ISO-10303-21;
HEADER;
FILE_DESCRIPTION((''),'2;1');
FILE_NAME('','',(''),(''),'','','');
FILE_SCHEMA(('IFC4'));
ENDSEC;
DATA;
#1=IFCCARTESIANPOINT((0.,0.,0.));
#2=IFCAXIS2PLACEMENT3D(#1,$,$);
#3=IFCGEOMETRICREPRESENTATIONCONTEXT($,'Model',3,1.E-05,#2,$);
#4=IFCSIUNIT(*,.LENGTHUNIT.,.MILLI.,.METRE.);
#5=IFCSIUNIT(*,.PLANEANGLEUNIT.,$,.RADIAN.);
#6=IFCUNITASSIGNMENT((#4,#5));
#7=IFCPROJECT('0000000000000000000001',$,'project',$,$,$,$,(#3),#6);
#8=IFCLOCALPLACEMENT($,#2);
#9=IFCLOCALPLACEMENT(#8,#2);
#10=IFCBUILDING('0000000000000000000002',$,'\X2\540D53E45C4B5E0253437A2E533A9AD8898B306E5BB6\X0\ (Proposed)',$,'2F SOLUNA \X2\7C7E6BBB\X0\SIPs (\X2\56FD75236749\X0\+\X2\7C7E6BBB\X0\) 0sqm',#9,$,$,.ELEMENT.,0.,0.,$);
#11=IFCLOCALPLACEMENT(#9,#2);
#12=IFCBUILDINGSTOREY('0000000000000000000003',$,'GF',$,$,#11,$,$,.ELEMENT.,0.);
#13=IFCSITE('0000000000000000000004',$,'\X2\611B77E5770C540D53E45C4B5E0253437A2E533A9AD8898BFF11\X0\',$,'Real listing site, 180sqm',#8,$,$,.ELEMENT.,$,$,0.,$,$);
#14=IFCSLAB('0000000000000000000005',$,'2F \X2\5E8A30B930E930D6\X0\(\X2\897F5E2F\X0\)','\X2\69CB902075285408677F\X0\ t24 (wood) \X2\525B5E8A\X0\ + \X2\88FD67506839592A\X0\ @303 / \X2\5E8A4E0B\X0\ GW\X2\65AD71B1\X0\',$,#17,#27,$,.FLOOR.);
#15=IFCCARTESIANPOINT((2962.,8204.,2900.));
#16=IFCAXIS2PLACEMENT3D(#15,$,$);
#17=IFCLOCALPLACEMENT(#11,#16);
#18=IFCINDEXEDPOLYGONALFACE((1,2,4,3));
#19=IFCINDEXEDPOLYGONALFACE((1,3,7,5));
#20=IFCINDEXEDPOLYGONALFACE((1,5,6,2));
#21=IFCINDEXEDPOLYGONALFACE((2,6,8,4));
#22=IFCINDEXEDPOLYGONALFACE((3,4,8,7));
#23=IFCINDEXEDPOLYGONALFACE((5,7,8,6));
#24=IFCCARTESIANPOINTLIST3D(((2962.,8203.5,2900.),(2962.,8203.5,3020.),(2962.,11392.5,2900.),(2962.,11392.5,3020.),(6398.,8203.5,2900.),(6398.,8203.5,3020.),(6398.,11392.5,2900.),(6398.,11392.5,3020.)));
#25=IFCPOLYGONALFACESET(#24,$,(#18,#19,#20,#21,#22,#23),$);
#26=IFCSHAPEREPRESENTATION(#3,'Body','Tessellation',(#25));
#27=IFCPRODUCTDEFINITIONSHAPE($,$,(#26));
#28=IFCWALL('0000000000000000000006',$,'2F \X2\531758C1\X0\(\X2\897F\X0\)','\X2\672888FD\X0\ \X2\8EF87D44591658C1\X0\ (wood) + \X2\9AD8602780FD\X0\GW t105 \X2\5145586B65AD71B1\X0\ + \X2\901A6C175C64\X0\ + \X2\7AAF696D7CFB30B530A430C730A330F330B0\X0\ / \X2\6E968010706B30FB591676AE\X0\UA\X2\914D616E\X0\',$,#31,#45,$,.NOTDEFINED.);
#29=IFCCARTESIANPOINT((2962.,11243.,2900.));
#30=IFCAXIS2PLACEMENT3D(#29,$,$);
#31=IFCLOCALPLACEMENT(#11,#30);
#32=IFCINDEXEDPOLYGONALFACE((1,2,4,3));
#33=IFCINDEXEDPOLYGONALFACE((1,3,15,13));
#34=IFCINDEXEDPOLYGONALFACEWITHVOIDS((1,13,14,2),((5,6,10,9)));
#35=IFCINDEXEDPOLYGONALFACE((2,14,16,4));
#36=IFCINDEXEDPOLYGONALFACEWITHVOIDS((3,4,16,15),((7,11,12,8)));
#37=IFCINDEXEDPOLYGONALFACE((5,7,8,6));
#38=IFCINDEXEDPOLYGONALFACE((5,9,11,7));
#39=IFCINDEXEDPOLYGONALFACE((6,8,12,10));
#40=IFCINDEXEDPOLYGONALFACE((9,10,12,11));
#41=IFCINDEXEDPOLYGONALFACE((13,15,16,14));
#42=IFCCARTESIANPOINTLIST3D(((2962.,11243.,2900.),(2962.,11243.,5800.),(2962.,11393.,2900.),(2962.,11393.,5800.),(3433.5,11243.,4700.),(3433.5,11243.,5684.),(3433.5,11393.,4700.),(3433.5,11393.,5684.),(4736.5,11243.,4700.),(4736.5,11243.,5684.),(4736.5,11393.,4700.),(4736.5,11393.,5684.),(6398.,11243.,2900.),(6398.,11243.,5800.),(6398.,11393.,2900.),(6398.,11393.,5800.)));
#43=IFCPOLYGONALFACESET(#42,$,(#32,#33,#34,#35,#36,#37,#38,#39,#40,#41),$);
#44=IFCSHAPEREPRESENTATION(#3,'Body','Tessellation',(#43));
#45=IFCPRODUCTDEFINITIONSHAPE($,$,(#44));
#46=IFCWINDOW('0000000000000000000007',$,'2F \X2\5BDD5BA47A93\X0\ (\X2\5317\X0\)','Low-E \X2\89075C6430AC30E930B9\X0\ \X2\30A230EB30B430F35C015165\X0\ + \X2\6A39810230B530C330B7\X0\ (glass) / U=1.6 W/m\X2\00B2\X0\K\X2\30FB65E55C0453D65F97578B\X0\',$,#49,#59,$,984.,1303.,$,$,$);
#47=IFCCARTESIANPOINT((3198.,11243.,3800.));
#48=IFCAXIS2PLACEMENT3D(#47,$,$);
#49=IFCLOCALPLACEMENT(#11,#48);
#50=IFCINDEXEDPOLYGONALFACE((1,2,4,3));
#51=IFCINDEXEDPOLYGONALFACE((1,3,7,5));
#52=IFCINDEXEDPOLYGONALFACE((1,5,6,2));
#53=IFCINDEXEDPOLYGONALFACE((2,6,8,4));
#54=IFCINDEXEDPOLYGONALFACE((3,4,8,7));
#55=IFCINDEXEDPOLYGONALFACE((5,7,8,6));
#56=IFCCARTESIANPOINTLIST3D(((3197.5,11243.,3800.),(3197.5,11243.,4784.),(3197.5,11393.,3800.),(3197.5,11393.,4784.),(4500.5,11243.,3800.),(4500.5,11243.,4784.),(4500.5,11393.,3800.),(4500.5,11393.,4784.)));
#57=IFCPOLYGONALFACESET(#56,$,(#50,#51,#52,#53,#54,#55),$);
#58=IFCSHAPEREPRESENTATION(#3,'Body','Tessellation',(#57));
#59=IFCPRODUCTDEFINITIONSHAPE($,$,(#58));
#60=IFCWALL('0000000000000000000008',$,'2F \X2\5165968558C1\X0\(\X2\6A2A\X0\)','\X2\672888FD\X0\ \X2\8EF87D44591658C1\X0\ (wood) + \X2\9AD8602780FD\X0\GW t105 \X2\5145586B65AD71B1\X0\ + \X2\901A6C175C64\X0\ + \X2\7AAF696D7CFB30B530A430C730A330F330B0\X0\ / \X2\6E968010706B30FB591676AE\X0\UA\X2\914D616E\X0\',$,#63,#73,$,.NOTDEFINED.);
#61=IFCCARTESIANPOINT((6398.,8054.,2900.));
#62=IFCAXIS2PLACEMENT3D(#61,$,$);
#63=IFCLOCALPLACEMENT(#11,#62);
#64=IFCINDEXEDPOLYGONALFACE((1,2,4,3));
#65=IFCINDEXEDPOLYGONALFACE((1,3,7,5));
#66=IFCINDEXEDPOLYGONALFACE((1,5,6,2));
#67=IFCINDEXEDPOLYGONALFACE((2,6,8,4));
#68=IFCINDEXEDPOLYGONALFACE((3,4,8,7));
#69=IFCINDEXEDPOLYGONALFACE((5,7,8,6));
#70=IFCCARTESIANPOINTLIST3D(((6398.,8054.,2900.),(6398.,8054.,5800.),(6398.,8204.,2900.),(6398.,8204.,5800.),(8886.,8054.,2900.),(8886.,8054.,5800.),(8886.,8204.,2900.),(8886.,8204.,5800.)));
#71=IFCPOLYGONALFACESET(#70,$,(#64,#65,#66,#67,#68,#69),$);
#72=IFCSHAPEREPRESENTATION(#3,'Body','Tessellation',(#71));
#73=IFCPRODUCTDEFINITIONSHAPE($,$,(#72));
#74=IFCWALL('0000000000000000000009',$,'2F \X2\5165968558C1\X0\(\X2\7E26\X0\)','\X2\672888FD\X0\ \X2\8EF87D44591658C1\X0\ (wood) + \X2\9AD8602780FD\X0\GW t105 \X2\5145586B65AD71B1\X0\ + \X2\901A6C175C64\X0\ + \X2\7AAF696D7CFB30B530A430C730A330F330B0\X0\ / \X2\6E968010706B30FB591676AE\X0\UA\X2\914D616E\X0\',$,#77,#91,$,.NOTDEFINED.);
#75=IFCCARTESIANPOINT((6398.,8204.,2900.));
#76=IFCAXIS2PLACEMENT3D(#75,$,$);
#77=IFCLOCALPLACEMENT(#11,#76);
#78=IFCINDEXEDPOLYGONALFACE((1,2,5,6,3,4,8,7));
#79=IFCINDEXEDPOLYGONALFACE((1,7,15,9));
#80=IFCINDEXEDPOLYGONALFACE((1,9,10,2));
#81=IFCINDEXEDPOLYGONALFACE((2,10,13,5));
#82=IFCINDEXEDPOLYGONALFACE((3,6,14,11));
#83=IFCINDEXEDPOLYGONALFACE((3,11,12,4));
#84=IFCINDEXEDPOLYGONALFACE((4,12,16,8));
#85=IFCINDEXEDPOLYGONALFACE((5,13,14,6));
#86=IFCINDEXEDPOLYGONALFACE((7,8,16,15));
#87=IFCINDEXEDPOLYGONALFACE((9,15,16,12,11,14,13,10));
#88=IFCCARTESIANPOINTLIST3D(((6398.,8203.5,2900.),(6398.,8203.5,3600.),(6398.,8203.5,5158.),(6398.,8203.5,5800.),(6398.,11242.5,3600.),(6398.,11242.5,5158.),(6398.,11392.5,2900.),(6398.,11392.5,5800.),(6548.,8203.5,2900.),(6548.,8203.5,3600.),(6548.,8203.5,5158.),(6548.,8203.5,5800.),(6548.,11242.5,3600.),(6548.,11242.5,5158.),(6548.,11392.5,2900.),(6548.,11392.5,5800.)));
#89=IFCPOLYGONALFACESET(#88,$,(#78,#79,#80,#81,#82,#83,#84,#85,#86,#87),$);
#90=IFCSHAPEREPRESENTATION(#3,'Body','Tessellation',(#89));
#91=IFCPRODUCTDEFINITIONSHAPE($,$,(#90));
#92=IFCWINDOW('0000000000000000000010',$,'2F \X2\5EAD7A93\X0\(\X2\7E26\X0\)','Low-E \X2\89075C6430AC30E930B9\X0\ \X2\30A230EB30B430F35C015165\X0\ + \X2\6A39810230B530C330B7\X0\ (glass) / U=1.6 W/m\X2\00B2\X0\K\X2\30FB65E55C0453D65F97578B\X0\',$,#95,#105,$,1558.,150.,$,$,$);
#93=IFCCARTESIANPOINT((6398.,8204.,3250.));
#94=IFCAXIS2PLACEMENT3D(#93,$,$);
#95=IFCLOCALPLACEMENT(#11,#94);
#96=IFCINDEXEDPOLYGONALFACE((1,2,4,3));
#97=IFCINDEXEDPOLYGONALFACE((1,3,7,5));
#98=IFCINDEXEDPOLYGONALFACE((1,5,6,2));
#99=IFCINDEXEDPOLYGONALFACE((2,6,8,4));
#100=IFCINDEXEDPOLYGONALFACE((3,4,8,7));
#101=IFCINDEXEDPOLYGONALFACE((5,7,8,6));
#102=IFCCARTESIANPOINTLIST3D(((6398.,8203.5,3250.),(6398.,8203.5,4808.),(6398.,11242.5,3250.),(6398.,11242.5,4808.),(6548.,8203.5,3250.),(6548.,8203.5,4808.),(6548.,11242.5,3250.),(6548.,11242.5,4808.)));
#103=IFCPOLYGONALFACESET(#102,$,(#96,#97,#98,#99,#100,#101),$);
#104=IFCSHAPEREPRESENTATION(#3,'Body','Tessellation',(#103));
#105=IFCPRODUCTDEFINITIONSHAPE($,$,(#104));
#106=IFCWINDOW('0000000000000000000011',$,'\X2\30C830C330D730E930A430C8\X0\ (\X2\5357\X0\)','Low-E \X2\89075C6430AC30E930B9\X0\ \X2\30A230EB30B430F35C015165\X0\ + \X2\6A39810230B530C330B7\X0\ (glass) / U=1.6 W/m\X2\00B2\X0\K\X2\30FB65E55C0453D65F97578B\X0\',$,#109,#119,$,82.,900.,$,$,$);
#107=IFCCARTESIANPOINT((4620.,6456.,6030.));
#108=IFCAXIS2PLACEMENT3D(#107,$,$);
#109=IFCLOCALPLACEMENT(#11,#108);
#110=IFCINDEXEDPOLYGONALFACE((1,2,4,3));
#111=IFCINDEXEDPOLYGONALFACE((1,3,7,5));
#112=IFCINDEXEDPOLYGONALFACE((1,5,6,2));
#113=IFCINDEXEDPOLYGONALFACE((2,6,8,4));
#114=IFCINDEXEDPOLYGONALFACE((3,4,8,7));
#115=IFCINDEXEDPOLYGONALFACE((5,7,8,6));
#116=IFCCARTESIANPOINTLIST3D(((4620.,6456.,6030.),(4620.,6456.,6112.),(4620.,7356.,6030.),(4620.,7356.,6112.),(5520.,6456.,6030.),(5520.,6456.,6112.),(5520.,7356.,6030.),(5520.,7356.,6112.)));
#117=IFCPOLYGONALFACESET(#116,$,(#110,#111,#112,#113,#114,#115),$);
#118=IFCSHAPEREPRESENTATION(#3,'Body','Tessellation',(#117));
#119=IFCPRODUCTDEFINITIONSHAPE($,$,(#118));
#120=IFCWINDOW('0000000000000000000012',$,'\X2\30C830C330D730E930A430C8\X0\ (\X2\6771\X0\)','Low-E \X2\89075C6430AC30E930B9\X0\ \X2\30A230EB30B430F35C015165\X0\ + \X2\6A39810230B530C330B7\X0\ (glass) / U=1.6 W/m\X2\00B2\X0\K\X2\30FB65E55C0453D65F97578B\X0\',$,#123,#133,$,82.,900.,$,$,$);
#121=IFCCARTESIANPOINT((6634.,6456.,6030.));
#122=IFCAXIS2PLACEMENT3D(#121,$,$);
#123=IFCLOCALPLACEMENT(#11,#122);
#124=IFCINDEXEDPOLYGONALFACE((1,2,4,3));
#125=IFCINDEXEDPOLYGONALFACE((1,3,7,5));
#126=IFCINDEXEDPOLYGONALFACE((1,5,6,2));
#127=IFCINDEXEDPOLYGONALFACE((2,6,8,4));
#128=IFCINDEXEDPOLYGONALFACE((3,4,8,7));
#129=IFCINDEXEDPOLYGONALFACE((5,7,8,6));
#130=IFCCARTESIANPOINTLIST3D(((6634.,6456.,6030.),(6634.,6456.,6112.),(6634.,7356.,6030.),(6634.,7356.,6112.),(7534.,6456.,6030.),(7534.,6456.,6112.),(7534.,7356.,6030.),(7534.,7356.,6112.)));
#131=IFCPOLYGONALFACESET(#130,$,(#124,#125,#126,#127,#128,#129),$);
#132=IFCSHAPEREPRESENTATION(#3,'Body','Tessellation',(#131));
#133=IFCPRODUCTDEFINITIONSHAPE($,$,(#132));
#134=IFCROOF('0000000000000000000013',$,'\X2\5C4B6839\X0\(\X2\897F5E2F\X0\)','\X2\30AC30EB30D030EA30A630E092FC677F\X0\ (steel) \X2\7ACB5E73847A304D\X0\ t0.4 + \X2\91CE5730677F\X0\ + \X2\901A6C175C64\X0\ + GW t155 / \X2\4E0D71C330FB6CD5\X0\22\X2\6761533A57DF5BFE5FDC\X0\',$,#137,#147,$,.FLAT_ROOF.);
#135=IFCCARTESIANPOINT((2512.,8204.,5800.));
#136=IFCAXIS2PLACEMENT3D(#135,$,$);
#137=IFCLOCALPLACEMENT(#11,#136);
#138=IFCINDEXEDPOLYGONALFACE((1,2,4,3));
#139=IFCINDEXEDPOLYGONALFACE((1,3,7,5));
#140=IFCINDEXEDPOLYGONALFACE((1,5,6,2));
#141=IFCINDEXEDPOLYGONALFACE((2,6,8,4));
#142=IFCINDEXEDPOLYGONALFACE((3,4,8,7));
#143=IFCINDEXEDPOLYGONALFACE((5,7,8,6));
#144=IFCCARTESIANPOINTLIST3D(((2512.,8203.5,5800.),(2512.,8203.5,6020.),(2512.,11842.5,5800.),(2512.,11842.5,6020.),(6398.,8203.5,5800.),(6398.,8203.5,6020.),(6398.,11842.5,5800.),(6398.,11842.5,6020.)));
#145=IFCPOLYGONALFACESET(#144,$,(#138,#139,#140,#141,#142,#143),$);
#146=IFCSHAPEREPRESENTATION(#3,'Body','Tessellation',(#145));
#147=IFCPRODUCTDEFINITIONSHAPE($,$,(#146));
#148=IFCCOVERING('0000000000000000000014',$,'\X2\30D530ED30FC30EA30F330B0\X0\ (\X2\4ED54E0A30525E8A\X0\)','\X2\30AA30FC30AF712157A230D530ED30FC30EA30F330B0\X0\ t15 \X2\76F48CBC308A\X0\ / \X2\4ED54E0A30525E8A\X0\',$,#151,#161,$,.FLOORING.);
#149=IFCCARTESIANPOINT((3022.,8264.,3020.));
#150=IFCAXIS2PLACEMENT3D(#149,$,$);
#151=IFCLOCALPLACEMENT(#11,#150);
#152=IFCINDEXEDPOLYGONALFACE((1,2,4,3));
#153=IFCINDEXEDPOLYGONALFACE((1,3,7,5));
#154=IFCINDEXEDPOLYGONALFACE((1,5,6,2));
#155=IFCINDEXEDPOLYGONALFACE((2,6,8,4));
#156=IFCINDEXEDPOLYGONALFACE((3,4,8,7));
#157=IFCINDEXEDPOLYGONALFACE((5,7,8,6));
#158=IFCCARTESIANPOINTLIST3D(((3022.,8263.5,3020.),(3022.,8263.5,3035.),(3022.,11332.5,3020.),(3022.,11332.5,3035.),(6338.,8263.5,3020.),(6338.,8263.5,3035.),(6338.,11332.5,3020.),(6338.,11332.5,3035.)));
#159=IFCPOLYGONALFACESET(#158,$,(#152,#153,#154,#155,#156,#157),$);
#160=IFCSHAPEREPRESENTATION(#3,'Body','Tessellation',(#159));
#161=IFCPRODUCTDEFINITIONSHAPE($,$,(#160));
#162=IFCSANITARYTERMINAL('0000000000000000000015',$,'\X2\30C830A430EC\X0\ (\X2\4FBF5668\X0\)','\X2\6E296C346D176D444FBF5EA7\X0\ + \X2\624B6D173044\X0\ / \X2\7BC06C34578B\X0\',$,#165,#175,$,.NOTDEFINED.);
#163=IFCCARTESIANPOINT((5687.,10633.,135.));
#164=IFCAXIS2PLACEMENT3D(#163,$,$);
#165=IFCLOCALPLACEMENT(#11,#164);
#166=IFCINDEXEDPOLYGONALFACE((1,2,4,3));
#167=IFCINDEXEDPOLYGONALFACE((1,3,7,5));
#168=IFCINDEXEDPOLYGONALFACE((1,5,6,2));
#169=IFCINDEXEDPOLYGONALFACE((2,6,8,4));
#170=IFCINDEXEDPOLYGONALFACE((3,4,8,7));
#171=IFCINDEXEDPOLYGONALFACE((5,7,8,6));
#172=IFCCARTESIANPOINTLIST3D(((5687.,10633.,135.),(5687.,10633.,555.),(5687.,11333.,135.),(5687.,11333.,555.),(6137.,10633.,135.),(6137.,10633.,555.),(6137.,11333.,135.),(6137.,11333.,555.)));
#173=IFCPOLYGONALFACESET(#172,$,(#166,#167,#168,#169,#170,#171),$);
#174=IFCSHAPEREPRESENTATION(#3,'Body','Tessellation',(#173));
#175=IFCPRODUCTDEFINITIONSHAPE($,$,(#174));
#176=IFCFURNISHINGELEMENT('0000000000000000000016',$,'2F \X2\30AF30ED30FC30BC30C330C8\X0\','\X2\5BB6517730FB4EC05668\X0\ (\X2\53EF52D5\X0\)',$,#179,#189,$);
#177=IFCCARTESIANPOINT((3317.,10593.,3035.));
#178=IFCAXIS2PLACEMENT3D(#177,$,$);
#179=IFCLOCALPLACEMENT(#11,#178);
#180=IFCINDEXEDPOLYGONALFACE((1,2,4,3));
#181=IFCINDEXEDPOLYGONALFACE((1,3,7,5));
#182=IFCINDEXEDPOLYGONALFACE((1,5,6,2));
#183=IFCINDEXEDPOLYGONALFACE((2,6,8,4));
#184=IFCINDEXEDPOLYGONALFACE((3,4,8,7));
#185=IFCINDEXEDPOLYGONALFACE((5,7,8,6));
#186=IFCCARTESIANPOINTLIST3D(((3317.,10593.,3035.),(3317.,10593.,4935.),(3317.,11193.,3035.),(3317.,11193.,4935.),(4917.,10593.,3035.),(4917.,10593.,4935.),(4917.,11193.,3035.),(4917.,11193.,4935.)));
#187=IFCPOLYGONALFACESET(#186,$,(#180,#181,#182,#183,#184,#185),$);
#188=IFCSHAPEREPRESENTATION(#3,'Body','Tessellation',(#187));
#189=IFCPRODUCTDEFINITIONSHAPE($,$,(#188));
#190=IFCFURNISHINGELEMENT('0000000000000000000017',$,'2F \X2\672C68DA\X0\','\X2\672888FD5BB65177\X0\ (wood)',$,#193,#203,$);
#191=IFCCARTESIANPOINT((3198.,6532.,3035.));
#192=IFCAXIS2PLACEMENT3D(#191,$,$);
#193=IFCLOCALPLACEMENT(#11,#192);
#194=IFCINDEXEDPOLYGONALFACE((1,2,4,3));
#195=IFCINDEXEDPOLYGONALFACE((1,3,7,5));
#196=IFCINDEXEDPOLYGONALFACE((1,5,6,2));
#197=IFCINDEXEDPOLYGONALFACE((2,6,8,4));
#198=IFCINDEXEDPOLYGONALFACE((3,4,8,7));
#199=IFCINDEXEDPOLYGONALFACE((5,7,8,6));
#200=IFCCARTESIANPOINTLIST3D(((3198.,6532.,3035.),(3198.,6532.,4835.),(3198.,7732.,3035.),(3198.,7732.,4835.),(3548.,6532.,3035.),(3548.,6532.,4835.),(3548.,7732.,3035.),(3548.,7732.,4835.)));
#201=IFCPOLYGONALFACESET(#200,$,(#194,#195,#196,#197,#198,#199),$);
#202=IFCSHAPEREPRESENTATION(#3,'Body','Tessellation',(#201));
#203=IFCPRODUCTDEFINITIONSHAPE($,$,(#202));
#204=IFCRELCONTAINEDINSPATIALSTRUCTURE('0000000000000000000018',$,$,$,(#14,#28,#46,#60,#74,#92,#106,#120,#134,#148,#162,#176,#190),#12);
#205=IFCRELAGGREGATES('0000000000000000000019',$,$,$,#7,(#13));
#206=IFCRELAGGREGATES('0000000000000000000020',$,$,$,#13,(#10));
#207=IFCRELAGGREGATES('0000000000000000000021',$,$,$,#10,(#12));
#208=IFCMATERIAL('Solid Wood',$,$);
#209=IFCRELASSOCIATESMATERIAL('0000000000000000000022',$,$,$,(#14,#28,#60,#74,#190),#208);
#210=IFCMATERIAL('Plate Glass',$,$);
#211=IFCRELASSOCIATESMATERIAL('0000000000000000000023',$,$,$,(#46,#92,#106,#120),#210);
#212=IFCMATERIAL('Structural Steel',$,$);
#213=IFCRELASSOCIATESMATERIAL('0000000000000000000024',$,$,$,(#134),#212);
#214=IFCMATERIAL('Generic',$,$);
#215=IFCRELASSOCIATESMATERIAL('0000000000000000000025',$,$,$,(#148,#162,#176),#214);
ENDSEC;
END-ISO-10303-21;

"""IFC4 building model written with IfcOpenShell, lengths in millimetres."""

from ifc_helpers import new_model, si_unit, frame, frame_2d, origin, place, context, project, spatial, rectangle, extrude, material, element, fill, save


model = new_model("IFC4")

# Units and contexts
model_context = context("Model", 3, precision=1e-05, world=origin())
ifc_project = project(units=[si_unit("LENGTHUNIT", "METRE", prefix="MILLI"), si_unit("PLANEANGLEUNIT", "RADIAN")], contexts=[model_context])

# Site, building, storey
site_placement = place(None, origin())
site = spatial("IfcSite", under=ifc_project, at=site_placement, Name="愛知県名古屋市千種区高見１", ObjectType="Real listing site, 180sqm", CompositionType="ELEMENT", RefElevation=0.0)
building_placement = place(site_placement, origin())
building = spatial("IfcBuilding", under=site, at=building_placement, Name="名古屋市千種区高見の家 (Proposed)", ObjectType="2F SOLUNA 籾殻SIPs (国産杉+籾殻) 0sqm", CompositionType="ELEMENT", ElevationOfRefHeight=0.0, ElevationOfTerrain=0.0)
storey_placement = place(building_placement, origin())
storey = spatial("IfcBuildingStorey", under=building, at=storey_placement, Name="GF", CompositionType="ELEMENT", Elevation=0.0)

# Slab
ifc_material_1 = material(Name="Solid Wood")
slab_placement = place(storey_placement, frame((2962.0, 8204.0, 2900.0)))
element("IfcSlab", 1, at=slab_placement, inside=storey, material=ifc_material_1, Name="2F 床スラブ(西帯)", Description="構造用合板 t24 (wood) 剛床 + 製材根太 @303 / 床下 GW断熱", PredefinedType="FLOOR", context=model_context, shape_type="SweptSolid", body=[
    extrude(rectangle(XDim=3436.0, YDim=3189.0, at=frame_2d((1718.0, 1594.0))), frame((2962.0, 8204.0, 2900.0)), (0.0, 0.0, 1.0), 120.0),
])

# Wall, opening, window
wall_1_placement = place(storey_placement, frame((2962.0, 11243.0, 2900.0)))
wall_1 = element("IfcWall", 2, at=wall_1_placement, inside=storey, material=ifc_material_1, Name="2F 北壁(西)", Description="木製 軸組外壁 (wood) + 高性能GW t105 充填断熱 + 通気層 + 窯業系サイディング / 準耐火・外皮UA配慮", PredefinedType="NOTDEFINED", context=model_context, shape_type="SweptSolid", body=[
    extrude(rectangle(XDim=3436.0, YDim=150.0, at=frame_2d((1718.0, 75.0))), frame((2962.0, 11243.0, 2900.0)), (0.0, 0.0, 1.0), 2900.0),
])
opening_1_placement = place(storey_placement, frame((3198.0, 11243.0, 3800.0)))
opening_1 = element("IfcOpeningElement", 3, at=opening_1_placement, cuts=wall_1, PredefinedType="NOTDEFINED", context=model_context, shape_type="SweptSolid", body=[
    extrude(rectangle(XDim=1303.0, YDim=150.0, at=frame_2d((651.0, 75.0))), frame((3198.0, 11243.0, 3800.0)), (0.0, 0.0, 1.0), 984.0),
])
ifc_material_2 = material(Name="Plate Glass")
window_1_placement = place(storey_placement, frame((3198.0, 11243.0, 3800.0)))
window_1 = element("IfcWindow", 4, at=window_1_placement, inside=storey, material=ifc_material_2, Name="2F 寝室窓 (北)", Description="Low-E 複層ガラス アルゴン封入 + 樹脂サッシ (glass) / U=1.6 W/m²K・日射取得型", OverallHeight=984.0, OverallWidth=1303.0, context=model_context, shape_type="SweptSolid", body=[
    extrude(rectangle(XDim=1303.0, YDim=150.0, at=frame_2d((651.0, 75.0))), frame((3198.0, 11243.0, 3800.0)), (0.0, 0.0, 1.0), 984.0),
])
fill(opening_1, window_1)

# Wall
wall_2_placement = place(storey_placement, frame((6398.0, 8054.0, 2900.0)))
element("IfcWall", 5, at=wall_2_placement, inside=storey, material=ifc_material_1, Name="2F 入隅壁(横)", Description="木製 軸組外壁 (wood) + 高性能GW t105 充填断熱 + 通気層 + 窯業系サイディング / 準耐火・外皮UA配慮", PredefinedType="NOTDEFINED", context=model_context, shape_type="SweptSolid", body=[
    extrude(rectangle(XDim=2488.0, YDim=150.0, at=frame_2d((1244.0, 75.0))), frame((6398.0, 8054.0, 2900.0)), (0.0, 0.0, 1.0), 2900.0),
])

# Wall, opening, window
wall_3_placement = place(storey_placement, frame((6398.0, 8204.0, 2900.0)))
wall_3 = element("IfcWall", 6, at=wall_3_placement, inside=storey, material=ifc_material_1, Name="2F 入隅壁(縦)", Description="木製 軸組外壁 (wood) + 高性能GW t105 充填断熱 + 通気層 + 窯業系サイディング / 準耐火・外皮UA配慮", PredefinedType="NOTDEFINED", context=model_context, shape_type="SweptSolid", body=[
    extrude(rectangle(XDim=150.0, YDim=3189.0, at=frame_2d((75.0, 1594.0))), frame((6398.0, 8204.0, 2900.0)), (0.0, 0.0, 1.0), 2900.0),
])
opening_2_placement = place(storey_placement, frame((6398.0, 8204.0, 3250.0)))
opening_2 = element("IfcOpeningElement", 7, at=opening_2_placement, cuts=wall_3, PredefinedType="NOTDEFINED", context=model_context, shape_type="SweptSolid", body=[
    extrude(rectangle(XDim=150.0, YDim=3039.0, at=frame_2d((75.0, 1519.0))), frame((6398.0, 8204.0, 3250.0)), (0.0, 0.0, 1.0), 1558.0),
])
window_2_placement = place(storey_placement, frame((6398.0, 8204.0, 3250.0)))
window_2 = element("IfcWindow", 8, at=window_2_placement, inside=storey, material=ifc_material_2, Name="2F 庭窓(縦)", Description="Low-E 複層ガラス アルゴン封入 + 樹脂サッシ (glass) / U=1.6 W/m²K・日射取得型", OverallHeight=1558.0, OverallWidth=150.0, context=model_context, shape_type="SweptSolid", body=[
    extrude(rectangle(XDim=150.0, YDim=3039.0, at=frame_2d((75.0, 1519.0))), frame((6398.0, 8204.0, 3250.0)), (0.0, 0.0, 1.0), 1558.0),
])
fill(opening_2, window_2)

# Windows
window_3_placement = place(storey_placement, frame((4620.0, 6456.0, 6030.0)))
element("IfcWindow", 9, at=window_3_placement, inside=storey, material=ifc_material_2, Name="トップライト (南)", Description="Low-E 複層ガラス アルゴン封入 + 樹脂サッシ (glass) / U=1.6 W/m²K・日射取得型", OverallHeight=82.0, OverallWidth=900.0, context=model_context, shape_type="SweptSolid", body=[
    extrude(rectangle(XDim=900.0, YDim=900.0, at=frame_2d((450.0, 450.0))), frame((4620.0, 6456.0, 6030.0)), (0.0, 0.0, 1.0), 82.0),
])
window_4_placement = place(storey_placement, frame((6634.0, 6456.0, 6030.0)))
element("IfcWindow", 10, at=window_4_placement, inside=storey, material=ifc_material_2, Name="トップライト (東)", Description="Low-E 複層ガラス アルゴン封入 + 樹脂サッシ (glass) / U=1.6 W/m²K・日射取得型", OverallHeight=82.0, OverallWidth=900.0, context=model_context, shape_type="SweptSolid", body=[
    extrude(rectangle(XDim=900.0, YDim=900.0, at=frame_2d((450.0, 450.0))), frame((6634.0, 6456.0, 6030.0)), (0.0, 0.0, 1.0), 82.0),
])

# Roof
ifc_material_3 = material(Name="Structural Steel")
for number, where, name in (
    (11, (2512.0, 8204.0, 5800.0), "屋根(西帯)"),
):
    element("IfcRoof", number, at=place(storey_placement, frame(where)), inside=storey, material=ifc_material_3, Name=name, Description="ガルバリウム鋼板 (steel) 立平葺き t0.4 + 野地板 + 通気層 + GW t155 / 不燃・法22条区域対応", PredefinedType="FLAT_ROOF", context=model_context, shape_type="SweptSolid", body=[
        extrude(rectangle(XDim=3886.0, YDim=3639.0, at=frame_2d((1943.0, 1819.0))), frame((2512.0, 8204.0, 5800.0)), (0.0, 0.0, 1.0), 220.0),
    ])

# Covering
ifc_material_4 = material(Name="Generic")
covering_placement = place(storey_placement, frame((3022.0, 8264.0, 3020.0)))
element("IfcCovering", 12, at=covering_placement, inside=storey, material=ifc_material_4, Name="フローリング (仕上げ床)", Description="オーク無垢フローリング t15 直貼り / 仕上げ床", PredefinedType="FLOORING", context=model_context, shape_type="SweptSolid", body=[
    extrude(rectangle(XDim=3316.0, YDim=3069.0, at=frame_2d((1658.0, 1534.0))), frame((3022.0, 8264.0, 3020.0)), (0.0, 0.0, 1.0), 15.0),
])

# Sanitary terminal
sanitary_terminal_placement = place(storey_placement, frame((5687.0, 10633.0, 135.0)))
element("IfcSanitaryTerminal", 13, at=sanitary_terminal_placement, inside=storey, material=ifc_material_4, Name="トイレ (便器)", Description="温水洗浄便座 + 手洗い / 節水型", PredefinedType="NOTDEFINED", context=model_context, shape_type="SweptSolid", body=[
    extrude(rectangle(XDim=450.0, YDim=700.0, at=frame_2d((225.0, 350.0))), frame((5687.0, 10633.0, 135.0)), (0.0, 0.0, 1.0), 420.0),
])

# Furnishing elements
furnishing_1_placement = place(storey_placement, frame((3317.0, 10593.0, 3035.0)))
element("IfcFurnishingElement", 14, at=furnishing_1_placement, inside=storey, material=ifc_material_4, Name="2F クローゼット", Description="家具・什器 (可動)", context=model_context, shape_type="SweptSolid", body=[
    extrude(rectangle(XDim=1600.0, YDim=600.0, at=frame_2d((800.0, 300.0))), frame((3317.0, 10593.0, 3035.0)), (0.0, 0.0, 1.0), 1900.0),
])
furnishing_2_placement = place(storey_placement, frame((3198.0, 6532.0, 3035.0)))
element("IfcFurnishingElement", 15, at=furnishing_2_placement, inside=storey, material=ifc_material_1, Name="2F 本棚", Description="木製家具 (wood)", context=model_context, shape_type="SweptSolid", body=[
    extrude(rectangle(XDim=350.0, YDim=1200.0, at=frame_2d((175.0, 600.0))), frame((3198.0, 6532.0, 3035.0)), (0.0, 0.0, 1.0), 1800.0),
])

save(model, "model.ifc")
